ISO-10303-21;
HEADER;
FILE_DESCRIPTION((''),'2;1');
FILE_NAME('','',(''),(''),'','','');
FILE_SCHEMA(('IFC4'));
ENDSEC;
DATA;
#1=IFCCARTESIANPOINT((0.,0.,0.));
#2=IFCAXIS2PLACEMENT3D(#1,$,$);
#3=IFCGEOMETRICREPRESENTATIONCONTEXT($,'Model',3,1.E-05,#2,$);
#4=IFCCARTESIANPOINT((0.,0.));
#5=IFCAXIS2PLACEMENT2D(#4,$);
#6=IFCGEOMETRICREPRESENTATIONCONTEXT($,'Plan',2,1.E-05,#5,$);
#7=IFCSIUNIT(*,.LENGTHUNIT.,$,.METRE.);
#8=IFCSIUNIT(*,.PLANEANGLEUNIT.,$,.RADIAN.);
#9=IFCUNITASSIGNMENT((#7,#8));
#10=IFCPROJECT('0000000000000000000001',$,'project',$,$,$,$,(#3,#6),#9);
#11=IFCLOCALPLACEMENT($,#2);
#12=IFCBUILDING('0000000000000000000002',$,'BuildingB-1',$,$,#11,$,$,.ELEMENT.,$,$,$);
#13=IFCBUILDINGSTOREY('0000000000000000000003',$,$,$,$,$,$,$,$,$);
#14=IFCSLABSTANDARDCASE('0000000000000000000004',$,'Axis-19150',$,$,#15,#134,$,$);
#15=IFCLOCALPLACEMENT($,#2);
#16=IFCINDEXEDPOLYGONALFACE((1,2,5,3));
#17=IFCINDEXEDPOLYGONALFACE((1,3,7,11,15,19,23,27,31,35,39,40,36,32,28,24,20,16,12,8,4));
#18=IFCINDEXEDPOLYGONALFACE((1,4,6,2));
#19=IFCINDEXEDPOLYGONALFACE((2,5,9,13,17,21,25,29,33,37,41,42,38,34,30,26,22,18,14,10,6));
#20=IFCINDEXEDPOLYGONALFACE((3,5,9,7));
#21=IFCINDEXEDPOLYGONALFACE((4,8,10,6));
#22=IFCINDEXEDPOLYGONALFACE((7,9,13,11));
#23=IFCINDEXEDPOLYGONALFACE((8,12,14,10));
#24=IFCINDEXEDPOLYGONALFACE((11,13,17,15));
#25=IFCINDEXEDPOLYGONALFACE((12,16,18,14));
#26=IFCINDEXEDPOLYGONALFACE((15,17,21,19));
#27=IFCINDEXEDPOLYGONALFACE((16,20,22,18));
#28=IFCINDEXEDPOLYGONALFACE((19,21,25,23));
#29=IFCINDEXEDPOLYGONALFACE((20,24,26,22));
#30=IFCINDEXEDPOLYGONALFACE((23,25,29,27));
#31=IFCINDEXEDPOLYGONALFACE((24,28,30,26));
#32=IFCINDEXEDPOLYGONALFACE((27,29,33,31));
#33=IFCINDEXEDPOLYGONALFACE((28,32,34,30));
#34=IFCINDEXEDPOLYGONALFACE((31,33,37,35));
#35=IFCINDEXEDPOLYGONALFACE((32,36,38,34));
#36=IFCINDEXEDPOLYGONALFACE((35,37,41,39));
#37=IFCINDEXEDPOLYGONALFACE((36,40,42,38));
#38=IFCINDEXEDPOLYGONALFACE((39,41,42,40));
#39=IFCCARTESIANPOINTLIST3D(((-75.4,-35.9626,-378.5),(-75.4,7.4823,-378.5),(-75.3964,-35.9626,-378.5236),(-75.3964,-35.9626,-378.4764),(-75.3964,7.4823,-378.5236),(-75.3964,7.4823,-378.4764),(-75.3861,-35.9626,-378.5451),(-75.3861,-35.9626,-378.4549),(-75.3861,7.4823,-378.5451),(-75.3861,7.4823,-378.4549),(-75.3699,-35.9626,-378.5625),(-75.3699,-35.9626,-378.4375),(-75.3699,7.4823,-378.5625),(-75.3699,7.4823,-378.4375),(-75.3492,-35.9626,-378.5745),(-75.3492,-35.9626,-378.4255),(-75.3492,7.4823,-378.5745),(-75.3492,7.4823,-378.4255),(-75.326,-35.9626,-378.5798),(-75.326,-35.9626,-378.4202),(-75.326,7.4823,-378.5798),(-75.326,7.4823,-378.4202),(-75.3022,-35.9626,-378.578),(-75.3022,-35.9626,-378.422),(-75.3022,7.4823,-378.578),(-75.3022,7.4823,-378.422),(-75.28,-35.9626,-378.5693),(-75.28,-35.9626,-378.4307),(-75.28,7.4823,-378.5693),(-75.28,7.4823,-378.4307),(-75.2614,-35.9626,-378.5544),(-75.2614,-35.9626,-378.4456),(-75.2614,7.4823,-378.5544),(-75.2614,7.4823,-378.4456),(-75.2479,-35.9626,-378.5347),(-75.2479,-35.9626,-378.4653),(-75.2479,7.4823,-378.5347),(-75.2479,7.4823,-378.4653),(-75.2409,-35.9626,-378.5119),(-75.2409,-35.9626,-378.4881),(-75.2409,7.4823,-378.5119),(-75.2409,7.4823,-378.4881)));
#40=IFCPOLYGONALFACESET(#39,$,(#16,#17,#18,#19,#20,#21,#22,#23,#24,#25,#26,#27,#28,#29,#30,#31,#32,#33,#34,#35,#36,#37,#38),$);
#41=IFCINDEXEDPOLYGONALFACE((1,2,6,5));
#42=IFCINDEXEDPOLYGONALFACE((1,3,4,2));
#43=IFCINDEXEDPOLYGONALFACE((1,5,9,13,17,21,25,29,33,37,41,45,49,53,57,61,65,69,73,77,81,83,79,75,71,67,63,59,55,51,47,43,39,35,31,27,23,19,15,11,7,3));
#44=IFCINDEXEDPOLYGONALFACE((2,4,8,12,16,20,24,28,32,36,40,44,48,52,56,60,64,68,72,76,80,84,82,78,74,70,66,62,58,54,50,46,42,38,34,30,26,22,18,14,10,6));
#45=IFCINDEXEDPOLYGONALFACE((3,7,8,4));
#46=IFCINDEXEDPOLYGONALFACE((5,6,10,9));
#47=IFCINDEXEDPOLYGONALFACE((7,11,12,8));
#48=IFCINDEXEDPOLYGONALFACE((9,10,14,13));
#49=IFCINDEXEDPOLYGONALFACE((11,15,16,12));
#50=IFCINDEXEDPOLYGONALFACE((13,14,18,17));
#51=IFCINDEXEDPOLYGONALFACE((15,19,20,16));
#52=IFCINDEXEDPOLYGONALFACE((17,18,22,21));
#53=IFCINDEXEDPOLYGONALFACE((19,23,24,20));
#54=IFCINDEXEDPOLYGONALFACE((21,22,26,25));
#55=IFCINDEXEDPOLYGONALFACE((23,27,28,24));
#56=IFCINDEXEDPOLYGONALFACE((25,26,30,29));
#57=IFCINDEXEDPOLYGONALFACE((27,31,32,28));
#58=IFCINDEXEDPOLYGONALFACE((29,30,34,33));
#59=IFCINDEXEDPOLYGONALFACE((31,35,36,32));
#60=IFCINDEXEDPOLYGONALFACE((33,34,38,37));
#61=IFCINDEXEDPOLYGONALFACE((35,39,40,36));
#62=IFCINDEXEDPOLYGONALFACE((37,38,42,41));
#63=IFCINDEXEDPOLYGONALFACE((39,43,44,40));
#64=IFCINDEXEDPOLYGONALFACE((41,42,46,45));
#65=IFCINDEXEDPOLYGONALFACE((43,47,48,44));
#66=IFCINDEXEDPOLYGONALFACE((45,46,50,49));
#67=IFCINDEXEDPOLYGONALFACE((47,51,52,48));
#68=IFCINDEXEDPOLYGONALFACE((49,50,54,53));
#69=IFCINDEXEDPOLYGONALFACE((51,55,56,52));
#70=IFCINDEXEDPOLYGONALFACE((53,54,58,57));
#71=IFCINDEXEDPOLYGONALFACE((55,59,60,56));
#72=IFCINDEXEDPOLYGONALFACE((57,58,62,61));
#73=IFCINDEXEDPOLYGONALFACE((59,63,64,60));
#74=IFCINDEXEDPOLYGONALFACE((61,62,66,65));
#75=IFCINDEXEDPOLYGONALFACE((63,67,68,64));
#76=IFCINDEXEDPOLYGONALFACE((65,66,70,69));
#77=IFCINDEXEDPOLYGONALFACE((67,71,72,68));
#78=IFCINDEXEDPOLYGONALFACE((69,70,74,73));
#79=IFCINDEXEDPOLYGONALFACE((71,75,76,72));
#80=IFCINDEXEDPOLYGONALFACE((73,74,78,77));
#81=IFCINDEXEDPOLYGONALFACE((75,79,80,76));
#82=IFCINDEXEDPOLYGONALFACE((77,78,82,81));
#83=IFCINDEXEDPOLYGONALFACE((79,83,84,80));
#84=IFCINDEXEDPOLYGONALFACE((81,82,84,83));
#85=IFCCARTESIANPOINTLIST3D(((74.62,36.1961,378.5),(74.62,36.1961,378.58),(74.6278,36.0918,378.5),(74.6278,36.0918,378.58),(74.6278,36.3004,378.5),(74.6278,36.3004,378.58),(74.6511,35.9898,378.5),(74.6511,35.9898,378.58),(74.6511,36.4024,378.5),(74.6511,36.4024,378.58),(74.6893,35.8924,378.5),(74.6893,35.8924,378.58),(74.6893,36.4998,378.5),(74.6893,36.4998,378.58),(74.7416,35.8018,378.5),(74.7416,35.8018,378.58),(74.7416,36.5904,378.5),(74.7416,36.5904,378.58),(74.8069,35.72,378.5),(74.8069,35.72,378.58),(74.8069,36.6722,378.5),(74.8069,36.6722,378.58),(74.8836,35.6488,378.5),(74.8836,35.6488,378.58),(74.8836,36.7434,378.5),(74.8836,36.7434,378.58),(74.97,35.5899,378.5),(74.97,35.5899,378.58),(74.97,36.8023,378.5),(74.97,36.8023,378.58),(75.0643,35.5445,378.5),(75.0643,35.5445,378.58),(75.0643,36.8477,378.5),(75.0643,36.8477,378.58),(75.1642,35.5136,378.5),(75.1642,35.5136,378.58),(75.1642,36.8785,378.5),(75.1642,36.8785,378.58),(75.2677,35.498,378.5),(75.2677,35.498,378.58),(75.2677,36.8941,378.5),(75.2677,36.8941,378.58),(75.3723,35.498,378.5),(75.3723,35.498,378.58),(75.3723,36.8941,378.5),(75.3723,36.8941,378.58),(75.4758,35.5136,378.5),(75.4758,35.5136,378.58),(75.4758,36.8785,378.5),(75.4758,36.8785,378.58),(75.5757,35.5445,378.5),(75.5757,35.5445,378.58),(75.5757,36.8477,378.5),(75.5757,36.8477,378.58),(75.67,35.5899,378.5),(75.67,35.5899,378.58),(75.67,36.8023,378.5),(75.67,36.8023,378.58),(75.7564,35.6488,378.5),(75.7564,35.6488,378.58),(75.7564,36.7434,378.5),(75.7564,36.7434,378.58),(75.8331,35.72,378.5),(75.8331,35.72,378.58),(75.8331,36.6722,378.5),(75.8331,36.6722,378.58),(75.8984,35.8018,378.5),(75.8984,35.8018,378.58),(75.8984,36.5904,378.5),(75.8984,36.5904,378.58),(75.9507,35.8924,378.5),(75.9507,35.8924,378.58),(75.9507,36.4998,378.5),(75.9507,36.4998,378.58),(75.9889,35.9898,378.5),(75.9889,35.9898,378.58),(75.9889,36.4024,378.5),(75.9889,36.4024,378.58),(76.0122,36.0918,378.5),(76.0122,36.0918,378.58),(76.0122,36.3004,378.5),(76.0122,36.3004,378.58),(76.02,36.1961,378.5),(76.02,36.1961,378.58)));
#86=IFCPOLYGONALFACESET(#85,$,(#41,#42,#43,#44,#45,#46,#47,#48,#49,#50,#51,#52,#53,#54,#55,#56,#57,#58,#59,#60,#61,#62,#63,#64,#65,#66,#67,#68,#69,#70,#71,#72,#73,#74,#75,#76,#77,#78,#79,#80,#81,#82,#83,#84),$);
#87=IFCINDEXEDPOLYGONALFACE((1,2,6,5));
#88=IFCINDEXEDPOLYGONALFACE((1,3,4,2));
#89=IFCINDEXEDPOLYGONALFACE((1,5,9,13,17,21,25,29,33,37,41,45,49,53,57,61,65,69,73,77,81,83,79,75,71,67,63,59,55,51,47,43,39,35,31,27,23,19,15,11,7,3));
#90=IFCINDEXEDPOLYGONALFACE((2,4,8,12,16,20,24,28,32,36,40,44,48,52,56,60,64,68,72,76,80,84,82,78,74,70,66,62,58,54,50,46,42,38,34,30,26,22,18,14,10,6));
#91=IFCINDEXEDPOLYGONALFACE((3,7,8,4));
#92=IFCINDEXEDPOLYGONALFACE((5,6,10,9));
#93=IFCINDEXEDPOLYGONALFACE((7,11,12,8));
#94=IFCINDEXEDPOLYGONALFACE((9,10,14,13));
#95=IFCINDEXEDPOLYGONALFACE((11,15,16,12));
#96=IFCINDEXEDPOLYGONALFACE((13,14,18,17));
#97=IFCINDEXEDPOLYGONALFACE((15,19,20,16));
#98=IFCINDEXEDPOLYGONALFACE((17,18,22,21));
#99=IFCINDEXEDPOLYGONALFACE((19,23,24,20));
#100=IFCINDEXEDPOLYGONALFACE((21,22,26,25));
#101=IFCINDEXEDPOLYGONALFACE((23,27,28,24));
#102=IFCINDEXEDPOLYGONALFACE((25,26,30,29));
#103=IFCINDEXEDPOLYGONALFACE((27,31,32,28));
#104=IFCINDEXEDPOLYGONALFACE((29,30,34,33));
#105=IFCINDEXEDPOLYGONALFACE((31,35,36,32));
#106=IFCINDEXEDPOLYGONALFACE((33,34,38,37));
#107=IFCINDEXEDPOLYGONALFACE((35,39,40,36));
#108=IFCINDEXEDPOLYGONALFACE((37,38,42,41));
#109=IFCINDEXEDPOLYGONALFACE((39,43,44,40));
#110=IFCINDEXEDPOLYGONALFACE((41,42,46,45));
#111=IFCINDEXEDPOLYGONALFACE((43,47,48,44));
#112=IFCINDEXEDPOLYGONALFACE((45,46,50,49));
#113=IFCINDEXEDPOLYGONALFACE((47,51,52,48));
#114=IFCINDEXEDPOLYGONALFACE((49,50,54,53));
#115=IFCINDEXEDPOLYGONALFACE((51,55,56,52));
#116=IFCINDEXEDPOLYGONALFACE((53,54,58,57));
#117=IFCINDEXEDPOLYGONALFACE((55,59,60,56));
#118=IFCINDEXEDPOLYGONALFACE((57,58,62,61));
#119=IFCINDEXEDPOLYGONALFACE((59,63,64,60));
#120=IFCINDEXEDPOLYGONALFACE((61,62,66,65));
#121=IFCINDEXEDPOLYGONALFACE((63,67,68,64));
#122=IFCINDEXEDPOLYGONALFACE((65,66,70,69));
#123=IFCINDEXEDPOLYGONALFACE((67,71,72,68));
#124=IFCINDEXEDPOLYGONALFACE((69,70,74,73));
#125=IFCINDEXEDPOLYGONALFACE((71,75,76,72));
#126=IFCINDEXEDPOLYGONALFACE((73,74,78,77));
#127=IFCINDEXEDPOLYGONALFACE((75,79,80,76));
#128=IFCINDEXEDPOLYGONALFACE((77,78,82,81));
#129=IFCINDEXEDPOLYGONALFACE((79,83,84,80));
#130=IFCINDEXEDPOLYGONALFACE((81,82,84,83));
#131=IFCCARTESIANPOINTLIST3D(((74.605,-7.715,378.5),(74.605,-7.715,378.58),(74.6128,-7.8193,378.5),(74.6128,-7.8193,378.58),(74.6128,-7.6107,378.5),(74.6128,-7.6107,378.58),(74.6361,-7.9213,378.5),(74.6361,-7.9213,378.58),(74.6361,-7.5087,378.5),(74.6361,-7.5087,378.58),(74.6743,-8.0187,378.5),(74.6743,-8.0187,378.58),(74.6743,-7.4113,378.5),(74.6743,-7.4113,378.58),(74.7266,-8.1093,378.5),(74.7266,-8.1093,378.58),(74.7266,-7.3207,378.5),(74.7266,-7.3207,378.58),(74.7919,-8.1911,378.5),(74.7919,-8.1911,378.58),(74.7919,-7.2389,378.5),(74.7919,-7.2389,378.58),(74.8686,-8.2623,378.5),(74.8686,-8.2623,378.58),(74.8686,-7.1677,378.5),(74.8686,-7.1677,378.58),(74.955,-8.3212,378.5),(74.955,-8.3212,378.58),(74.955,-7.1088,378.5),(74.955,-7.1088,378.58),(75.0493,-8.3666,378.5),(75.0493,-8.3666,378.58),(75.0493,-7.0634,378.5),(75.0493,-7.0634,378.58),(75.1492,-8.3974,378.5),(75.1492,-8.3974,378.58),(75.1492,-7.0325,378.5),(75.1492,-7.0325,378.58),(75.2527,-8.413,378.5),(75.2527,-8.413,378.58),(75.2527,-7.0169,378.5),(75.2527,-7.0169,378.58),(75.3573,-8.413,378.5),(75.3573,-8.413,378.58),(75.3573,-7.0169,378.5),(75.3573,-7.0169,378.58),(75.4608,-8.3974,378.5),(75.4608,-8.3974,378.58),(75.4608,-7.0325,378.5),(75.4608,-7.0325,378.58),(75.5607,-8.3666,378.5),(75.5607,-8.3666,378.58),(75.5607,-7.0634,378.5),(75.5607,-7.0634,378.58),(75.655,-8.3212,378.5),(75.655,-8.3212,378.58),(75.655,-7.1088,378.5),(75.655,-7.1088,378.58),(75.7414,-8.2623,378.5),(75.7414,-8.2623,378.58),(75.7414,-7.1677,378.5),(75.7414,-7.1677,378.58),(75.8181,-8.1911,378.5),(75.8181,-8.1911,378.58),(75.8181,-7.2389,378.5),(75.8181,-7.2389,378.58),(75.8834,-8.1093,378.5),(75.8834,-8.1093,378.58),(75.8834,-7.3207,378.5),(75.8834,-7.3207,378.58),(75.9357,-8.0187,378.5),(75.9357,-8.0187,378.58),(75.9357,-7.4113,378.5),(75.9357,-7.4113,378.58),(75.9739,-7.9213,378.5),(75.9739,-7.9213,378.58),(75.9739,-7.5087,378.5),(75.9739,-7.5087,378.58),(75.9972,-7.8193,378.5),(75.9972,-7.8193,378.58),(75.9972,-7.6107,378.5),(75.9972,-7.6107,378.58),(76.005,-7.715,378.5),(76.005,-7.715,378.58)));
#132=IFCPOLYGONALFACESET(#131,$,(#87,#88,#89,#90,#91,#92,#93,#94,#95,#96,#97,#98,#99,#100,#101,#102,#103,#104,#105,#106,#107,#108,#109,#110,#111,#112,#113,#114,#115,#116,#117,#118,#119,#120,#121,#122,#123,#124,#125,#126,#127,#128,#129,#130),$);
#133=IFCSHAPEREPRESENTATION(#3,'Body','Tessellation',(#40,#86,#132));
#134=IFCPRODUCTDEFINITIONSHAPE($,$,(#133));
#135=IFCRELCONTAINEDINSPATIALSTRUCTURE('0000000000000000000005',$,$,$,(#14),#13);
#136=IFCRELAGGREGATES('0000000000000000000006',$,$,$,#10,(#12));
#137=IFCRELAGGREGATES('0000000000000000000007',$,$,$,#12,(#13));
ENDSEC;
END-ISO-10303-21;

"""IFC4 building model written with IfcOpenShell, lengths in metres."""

from ifc_helpers import new_model, entity, si_unit, frame, origin, origin_2d, place, context, project, spatial, circle, extrude, element, save


model = new_model("IFC4")

# Units and contexts
model_context = context("Model", 3, precision=1e-05, world=origin())
plan_context = context("Plan", 2, precision=1e-05, world=origin_2d())
ifc_project = project(units=[si_unit("LENGTHUNIT", "METRE"), si_unit("PLANEANGLEUNIT", "RADIAN")], contexts=[model_context, plan_context])

# Building, storey
building_placement = place(None, origin())
building = spatial("IfcBuilding", under=ifc_project, at=building_placement, Name="BuildingB-1", CompositionType="ELEMENT")
storey = spatial("IfcBuildingStorey", under=building)

# Slab
element("IfcSlabStandardCase", 1, inside=storey, Name="Axis-19150", context=model_context, shape_type="AdvancedSweptSolid", body=[
    entity("IfcSurfaceCurveSweptAreaSolid", entity("IfcCircleProfileDef", "AREA", None, None, 0.08), None, entity("IfcPolyline", [entity("IfcCartesianPoint", [75.32, 35.9626, 378.5]), entity("IfcCartesianPoint", [75.32, -7.4823, 378.5])]), None, None, entity("IfcPlane", entity("IfcAxis2Placement3D", entity("IfcCartesianPoint", [75.32, 35.9626, 378.5]), entity("IfcDirection", [0.0, 0.0, 1.0]), entity("IfcDirection", [1.0, 0.0, 0.0])))),
    extrude(circle(Radius=0.7), frame((75.32, 36.1961, 378.5)), (0.0, 0.0, 1.0), 0.08),
    extrude(circle(Radius=0.7), frame((75.305, -7.715, 378.5)), (0.0, 0.0, 1.0), 0.08),
])

save(model, "model.ifc")
